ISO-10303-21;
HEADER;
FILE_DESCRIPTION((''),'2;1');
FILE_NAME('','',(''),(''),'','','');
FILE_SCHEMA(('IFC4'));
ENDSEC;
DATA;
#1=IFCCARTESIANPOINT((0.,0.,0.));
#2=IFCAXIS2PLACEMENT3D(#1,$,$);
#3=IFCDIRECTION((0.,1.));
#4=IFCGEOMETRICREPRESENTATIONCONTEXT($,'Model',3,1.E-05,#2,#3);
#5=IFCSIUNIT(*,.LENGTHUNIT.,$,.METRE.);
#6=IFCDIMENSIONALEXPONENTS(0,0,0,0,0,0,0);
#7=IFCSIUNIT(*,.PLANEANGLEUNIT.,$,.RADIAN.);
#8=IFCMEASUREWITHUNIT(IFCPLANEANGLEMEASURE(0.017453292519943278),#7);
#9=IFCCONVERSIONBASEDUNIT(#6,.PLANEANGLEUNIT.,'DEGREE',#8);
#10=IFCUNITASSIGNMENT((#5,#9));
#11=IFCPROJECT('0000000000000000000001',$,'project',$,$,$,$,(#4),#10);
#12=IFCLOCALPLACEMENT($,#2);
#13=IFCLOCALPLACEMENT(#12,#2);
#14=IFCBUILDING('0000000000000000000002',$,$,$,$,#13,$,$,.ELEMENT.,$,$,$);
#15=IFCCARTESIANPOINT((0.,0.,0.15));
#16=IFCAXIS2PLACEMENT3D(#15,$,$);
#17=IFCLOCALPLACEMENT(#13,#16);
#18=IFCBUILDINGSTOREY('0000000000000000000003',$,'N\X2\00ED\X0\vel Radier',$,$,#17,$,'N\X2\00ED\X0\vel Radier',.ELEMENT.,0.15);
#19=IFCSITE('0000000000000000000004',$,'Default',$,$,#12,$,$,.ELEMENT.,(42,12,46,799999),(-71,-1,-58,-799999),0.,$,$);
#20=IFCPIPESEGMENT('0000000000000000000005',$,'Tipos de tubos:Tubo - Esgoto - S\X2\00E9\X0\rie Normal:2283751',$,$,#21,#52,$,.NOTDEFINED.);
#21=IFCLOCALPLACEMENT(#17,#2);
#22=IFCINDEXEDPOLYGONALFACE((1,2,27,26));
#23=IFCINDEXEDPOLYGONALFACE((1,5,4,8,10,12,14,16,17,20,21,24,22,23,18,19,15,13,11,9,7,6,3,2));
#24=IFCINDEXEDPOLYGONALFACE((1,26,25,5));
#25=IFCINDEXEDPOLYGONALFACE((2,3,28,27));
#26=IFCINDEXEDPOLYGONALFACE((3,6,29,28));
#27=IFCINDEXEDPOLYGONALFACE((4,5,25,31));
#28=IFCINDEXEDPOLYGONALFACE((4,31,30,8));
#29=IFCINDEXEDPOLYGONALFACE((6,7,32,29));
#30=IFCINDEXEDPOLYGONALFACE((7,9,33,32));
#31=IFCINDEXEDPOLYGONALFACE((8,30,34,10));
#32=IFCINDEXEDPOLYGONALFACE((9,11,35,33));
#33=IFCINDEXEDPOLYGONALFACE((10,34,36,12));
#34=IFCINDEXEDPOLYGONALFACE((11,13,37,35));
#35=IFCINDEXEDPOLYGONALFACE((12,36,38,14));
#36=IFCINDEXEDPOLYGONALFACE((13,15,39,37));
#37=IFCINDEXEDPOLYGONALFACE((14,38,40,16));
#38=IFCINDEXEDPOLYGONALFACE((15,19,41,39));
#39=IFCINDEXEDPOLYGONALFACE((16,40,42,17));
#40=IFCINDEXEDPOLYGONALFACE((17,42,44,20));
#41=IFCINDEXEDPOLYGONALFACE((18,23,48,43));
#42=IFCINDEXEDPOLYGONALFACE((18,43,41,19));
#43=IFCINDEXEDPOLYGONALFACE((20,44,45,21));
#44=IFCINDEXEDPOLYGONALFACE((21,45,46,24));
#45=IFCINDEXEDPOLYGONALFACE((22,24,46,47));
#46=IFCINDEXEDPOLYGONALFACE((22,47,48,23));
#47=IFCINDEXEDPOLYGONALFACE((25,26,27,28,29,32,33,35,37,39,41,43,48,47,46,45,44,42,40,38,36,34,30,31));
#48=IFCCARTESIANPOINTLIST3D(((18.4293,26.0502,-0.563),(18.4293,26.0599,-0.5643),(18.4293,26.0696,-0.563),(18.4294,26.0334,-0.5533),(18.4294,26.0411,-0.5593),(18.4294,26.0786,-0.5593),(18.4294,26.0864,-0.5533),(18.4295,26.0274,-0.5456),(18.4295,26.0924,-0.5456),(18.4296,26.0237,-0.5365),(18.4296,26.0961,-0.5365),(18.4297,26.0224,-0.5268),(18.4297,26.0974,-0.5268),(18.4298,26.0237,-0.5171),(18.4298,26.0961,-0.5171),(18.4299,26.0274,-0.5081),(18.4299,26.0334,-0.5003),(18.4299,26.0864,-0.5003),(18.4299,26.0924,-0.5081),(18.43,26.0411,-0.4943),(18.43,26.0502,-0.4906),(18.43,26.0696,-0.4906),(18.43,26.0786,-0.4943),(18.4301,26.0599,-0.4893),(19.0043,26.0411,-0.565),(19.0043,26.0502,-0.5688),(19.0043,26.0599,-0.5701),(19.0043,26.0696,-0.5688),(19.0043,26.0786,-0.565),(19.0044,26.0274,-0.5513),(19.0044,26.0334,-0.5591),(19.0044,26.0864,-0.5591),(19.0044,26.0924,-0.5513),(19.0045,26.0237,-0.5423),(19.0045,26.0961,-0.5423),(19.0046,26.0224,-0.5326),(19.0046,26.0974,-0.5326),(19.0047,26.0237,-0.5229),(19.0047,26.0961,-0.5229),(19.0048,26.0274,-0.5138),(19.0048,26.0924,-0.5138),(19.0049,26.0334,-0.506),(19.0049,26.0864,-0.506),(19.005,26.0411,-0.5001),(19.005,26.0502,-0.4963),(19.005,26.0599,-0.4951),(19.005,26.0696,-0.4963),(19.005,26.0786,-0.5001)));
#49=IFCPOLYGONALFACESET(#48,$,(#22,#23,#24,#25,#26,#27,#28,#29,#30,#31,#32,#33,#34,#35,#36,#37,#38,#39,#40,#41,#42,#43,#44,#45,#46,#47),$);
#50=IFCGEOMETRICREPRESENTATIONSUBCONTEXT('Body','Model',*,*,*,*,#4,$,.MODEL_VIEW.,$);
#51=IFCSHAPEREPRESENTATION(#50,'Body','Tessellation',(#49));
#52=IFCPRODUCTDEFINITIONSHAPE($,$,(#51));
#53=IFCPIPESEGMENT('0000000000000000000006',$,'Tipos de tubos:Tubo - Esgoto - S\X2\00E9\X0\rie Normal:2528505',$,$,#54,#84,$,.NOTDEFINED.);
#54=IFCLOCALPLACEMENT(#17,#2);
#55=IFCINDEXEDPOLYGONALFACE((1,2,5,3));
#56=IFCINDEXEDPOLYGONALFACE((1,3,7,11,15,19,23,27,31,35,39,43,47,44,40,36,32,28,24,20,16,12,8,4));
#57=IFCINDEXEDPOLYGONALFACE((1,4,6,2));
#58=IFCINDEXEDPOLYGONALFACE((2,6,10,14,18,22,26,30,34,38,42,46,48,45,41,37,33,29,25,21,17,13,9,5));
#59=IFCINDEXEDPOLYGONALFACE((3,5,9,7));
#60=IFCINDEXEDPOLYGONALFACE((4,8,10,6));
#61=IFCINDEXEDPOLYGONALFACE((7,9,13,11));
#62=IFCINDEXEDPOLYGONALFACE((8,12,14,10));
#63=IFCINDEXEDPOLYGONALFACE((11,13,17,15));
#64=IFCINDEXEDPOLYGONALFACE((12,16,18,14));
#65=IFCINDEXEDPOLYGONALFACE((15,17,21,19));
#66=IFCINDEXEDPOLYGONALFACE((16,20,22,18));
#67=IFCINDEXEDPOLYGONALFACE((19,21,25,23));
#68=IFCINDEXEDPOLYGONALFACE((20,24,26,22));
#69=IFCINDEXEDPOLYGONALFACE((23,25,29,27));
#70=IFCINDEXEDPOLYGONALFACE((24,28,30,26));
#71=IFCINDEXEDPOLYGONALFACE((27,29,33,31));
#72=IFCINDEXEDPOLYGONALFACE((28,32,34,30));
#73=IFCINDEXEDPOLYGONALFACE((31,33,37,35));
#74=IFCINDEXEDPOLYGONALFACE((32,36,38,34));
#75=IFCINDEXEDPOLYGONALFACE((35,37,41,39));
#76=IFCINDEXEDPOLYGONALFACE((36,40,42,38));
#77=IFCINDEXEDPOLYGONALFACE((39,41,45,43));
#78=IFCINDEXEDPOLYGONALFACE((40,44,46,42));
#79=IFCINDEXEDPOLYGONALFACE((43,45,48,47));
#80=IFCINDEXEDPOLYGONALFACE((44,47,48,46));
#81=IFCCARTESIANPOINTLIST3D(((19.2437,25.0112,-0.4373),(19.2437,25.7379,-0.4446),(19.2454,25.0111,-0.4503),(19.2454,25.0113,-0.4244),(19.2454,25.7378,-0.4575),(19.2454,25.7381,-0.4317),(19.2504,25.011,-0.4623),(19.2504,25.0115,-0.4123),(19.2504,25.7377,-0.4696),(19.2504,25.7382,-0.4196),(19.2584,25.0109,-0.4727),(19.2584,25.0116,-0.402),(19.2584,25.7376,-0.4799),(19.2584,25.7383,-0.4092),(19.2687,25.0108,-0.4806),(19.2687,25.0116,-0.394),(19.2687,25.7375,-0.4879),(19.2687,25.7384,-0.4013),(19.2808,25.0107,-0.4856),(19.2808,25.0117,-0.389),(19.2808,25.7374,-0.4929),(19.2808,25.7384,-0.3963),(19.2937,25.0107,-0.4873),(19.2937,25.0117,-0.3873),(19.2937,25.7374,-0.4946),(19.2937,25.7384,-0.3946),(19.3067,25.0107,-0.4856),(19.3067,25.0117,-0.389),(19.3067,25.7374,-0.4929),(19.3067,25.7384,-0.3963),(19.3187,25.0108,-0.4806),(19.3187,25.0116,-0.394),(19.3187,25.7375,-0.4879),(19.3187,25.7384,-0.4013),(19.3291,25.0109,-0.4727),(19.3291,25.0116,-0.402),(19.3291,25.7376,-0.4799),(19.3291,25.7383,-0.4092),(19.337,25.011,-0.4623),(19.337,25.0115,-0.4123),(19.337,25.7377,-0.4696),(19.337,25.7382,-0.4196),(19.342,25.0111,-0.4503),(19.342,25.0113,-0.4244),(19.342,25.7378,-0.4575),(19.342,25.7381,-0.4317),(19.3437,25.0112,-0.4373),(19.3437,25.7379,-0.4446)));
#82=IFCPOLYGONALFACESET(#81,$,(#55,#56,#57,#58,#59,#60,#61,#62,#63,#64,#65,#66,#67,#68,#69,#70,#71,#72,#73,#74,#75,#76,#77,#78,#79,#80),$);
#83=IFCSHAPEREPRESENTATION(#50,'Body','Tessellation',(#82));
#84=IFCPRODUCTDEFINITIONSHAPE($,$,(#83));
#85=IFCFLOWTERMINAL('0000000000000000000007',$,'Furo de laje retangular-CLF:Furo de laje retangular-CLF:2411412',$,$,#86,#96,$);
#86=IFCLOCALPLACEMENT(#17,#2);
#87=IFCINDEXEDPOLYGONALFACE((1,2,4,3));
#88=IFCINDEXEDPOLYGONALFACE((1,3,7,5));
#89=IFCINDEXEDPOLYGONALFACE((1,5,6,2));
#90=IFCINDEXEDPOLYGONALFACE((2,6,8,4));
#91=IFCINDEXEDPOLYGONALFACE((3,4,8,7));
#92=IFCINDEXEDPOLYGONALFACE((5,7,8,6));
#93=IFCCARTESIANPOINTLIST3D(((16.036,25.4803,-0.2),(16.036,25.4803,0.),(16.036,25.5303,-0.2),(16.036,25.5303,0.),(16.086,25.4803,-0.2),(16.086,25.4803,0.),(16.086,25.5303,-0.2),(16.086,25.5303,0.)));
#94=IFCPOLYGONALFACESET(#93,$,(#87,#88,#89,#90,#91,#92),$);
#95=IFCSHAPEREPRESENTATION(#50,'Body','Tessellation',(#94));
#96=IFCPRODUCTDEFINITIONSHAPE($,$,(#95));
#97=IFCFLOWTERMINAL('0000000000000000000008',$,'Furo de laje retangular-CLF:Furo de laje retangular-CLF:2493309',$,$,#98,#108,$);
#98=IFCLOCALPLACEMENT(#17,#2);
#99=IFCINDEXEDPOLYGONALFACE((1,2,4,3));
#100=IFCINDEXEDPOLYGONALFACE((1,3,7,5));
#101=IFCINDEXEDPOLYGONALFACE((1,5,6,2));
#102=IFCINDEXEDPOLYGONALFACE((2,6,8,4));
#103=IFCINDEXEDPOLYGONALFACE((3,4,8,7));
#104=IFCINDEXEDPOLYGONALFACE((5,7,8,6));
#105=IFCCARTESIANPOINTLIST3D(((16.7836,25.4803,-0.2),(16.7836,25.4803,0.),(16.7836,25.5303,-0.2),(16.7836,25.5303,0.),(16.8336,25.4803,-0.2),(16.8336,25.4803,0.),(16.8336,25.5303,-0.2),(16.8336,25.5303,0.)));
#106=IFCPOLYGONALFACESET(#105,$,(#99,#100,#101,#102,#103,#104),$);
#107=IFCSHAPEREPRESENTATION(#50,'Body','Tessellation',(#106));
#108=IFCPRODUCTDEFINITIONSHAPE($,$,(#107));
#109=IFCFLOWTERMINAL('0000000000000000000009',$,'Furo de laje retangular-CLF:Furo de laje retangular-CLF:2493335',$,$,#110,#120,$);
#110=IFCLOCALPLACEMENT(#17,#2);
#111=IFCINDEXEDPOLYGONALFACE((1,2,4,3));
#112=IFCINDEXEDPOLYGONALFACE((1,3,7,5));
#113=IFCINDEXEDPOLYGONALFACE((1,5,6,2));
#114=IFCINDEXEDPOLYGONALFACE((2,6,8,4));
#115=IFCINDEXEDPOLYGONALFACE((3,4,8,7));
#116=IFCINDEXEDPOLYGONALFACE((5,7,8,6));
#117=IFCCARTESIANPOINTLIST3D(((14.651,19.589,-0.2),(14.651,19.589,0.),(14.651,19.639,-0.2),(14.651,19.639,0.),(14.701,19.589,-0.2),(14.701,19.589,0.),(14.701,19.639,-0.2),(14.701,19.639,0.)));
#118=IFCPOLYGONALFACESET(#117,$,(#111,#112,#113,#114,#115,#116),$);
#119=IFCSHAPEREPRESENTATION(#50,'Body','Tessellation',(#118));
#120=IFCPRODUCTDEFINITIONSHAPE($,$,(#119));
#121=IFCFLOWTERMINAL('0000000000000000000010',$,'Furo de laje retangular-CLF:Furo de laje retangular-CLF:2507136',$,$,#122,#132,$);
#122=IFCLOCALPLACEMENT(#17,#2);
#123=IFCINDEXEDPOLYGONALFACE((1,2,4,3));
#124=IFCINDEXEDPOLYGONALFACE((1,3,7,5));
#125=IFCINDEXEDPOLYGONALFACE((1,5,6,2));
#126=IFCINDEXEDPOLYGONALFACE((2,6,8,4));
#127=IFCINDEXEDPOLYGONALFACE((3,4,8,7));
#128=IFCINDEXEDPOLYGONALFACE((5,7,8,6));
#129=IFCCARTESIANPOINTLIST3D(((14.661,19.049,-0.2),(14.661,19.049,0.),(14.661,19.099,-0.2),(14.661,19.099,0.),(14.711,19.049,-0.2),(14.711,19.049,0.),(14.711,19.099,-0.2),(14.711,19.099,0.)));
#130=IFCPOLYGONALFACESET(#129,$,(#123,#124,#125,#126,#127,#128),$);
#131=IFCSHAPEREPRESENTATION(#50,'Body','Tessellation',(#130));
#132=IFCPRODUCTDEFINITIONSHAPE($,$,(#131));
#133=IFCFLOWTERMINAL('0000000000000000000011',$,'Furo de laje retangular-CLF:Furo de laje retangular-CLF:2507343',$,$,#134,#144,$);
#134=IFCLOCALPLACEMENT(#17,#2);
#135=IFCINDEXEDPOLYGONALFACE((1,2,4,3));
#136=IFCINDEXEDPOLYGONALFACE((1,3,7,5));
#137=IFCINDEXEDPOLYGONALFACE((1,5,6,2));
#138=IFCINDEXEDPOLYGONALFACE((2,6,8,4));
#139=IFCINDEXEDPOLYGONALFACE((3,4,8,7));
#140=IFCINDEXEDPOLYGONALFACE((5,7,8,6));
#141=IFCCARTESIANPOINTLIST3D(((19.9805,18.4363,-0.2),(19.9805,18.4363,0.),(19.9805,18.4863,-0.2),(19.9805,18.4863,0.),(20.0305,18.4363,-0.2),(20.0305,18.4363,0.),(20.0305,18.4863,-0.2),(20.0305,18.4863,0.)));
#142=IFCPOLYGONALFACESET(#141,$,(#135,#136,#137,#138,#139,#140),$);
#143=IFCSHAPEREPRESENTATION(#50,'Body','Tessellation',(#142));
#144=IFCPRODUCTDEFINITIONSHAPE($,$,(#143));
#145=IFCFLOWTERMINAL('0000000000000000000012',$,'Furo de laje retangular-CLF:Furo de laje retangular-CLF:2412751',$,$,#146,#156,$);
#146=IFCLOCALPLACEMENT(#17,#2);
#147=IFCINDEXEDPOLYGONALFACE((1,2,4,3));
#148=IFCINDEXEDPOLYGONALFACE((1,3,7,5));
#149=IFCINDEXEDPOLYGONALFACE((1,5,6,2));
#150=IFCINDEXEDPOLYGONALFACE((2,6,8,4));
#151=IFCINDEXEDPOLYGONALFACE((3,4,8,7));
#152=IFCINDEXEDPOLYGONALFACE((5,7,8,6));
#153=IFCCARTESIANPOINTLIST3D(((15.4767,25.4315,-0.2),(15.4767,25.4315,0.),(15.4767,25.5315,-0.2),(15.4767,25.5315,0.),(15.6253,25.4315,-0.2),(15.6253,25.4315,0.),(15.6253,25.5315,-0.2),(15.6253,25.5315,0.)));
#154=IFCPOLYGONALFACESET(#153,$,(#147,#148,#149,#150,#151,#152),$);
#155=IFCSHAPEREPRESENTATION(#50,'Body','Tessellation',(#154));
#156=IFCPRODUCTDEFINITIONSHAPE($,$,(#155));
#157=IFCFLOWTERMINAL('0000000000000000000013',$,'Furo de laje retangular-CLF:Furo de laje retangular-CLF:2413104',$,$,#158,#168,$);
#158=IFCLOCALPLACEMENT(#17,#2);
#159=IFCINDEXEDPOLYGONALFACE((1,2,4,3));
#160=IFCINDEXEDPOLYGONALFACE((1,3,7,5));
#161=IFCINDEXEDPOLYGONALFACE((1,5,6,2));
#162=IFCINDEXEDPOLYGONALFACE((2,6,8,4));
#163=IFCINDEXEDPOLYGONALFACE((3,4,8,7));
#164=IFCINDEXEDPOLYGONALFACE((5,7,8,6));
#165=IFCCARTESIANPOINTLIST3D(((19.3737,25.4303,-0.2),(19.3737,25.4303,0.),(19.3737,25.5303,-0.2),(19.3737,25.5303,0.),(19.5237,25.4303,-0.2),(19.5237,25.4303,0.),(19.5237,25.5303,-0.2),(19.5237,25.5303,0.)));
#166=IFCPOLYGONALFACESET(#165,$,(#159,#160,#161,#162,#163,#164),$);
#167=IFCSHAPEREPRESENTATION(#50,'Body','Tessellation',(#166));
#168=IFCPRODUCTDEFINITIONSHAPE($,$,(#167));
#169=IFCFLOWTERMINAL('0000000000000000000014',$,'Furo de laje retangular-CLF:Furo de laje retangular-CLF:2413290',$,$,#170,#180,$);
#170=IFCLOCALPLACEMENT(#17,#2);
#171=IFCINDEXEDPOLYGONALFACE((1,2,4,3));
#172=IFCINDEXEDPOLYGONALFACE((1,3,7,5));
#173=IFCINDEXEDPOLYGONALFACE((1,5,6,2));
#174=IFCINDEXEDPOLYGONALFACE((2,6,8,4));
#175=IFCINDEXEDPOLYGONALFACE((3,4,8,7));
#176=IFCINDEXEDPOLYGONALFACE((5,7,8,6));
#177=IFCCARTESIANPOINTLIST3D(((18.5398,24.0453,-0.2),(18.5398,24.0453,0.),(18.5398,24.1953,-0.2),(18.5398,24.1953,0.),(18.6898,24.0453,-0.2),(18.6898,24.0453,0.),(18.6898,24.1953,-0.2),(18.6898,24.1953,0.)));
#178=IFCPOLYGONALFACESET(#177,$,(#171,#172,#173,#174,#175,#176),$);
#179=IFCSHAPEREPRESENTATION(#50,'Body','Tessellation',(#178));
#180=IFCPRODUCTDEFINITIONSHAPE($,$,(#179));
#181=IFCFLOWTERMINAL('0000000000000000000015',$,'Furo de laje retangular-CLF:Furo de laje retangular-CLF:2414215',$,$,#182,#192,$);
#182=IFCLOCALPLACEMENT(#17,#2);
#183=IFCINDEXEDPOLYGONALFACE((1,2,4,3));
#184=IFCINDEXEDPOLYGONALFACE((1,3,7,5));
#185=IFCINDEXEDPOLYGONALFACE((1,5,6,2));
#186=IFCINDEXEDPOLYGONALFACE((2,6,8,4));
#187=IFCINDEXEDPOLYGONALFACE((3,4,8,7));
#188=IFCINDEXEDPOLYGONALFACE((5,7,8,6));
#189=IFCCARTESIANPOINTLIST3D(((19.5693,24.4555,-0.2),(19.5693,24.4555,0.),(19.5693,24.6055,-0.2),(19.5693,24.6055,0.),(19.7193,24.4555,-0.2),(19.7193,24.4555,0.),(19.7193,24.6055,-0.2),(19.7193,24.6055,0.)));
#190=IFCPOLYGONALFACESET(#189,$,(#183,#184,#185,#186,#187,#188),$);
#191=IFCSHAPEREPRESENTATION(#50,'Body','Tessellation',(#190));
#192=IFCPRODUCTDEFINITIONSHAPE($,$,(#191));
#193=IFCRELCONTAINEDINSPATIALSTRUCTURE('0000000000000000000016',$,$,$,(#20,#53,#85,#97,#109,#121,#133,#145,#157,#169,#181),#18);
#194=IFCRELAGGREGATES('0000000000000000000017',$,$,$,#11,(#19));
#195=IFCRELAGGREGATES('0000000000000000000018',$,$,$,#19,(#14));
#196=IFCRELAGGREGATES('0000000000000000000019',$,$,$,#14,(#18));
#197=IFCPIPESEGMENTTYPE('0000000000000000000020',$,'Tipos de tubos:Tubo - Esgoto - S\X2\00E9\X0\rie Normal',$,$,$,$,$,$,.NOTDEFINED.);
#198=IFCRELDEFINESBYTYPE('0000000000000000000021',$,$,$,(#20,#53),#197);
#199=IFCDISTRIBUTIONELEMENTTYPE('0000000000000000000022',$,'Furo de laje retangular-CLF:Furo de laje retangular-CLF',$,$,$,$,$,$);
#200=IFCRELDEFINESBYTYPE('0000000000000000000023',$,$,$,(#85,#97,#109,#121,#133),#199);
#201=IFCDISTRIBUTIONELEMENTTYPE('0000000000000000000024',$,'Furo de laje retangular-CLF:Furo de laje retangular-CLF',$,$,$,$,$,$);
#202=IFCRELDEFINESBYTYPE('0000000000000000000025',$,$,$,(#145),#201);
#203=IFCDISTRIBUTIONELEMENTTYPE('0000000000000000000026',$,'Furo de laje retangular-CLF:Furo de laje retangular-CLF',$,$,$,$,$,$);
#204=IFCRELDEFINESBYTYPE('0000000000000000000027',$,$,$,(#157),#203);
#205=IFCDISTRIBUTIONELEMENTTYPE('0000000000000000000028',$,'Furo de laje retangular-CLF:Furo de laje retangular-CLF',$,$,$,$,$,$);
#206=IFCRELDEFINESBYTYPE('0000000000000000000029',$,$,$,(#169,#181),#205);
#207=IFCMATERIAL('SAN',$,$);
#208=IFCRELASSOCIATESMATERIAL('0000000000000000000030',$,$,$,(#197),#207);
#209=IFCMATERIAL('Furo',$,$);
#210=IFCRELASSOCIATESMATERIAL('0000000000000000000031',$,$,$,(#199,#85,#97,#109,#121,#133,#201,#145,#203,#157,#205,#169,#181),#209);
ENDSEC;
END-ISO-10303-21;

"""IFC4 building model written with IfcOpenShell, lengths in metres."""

from ifc_helpers import new_model, entity, si_unit, converted_unit, direction, frame, origin, place, context, subcontext, project, spatial, arc, indexed_curve, outline, extrude, source, transform, mapped, material, type_object, type_shapes, element, save


model = new_model("IFC4")

# Units and contexts
model_context = context("Model", 3, precision=1e-05, world=origin(), true_north=direction((0.0, 1.0)))
body_context = subcontext(model_context, "Body", "Model", "MODEL_VIEW")
ifc_project = project(units=[si_unit("LENGTHUNIT", "METRE"), converted_unit("PLANEANGLEUNIT", "DEGREE", entity("IfcPlaneAngleMeasure", 0.017453292519943278), si_unit("PLANEANGLEUNIT", "RADIAN"), dimensions=[0, 0, 0, 0, 0, 0, 0])], contexts=[model_context])

# Site, building, storey
site_placement = place(None, origin())
site = spatial("IfcSite", under=ifc_project, at=site_placement, Name="Default", CompositionType="ELEMENT", RefLatitude=(42, 12, 46, 799999), RefLongitude=(-71, -1, -58, -799999), RefElevation=0.0)
building_placement = place(site_placement, origin())
building = spatial("IfcBuilding", under=site, at=building_placement, CompositionType="ELEMENT")
storey_placement = place(building_placement, frame((0.0, 0.0, 0.15)))
storey = spatial("IfcBuildingStorey", under=building, at=storey_placement, Name="Nível Radier", LongName="Nível Radier", CompositionType="ELEMENT", Elevation=0.15)

# Pipe segments
ifc_material_1 = material(Name="SAN")
pipe_segment_type = type_object("IfcPipeSegmentType", Name="Tipos de tubos:Tubo - Esgoto - Série Normal", PredefinedType="NOTDEFINED", material=ifc_material_1)
pipe_segment_1_placement = place(storey_placement, origin())
element("IfcPipeSegment", 1, at=pipe_segment_1_placement, inside=storey, type_object=pipe_segment_type, Name="Tipos de tubos:Tubo - Esgoto - Série Normal:2283751", PredefinedType="NOTDEFINED", context=body_context, shape_type="SweptSolid", body=[
    extrude(outline(indexed_curve([(0.0375, 0.0), (0.0265, 0.0265), (0.0, 0.0375), (-0.0265, 0.0265), (-0.0375, 0.0), (-0.0265, -0.0265), (0.0, -0.0375), (0.0265, -0.0265)], segments=[arc(1, 2, 3), arc(3, 4, 5), arc(5, 6, 7), arc(7, 8, 1)], self_intersect=False)), frame((19.0046, 26.0599, -0.5326), z_axis=(-0.99995, -0.000003, 0.01), x_axis=(0.000003, -1.0, 0.0)), (0.0, 0.0, 1.0), 0.575),
])
pipe_segment_2_placement = place(storey_placement, origin())
element("IfcPipeSegment", 2, at=pipe_segment_2_placement, inside=storey, type_object=pipe_segment_type, Name="Tipos de tubos:Tubo - Esgoto - Série Normal:2528505", PredefinedType="NOTDEFINED", context=body_context, shape_type="SweptSolid", body=[
    extrude(outline(indexed_curve([(0.05, 0.0), (0.0354, 0.0354), (0.0, 0.05), (-0.0354, 0.0354), (-0.05, 0.0), (-0.0354, -0.0354), (0.0, -0.05), (0.0354, -0.0354)], segments=[arc(1, 2, 3), arc(3, 4, 5), arc(5, 6, 7), arc(7, 8, 1)], self_intersect=False)), frame((19.2937, 25.0112, -0.4373), z_axis=(0.0, 0.99995, -0.01), x_axis=(1.0, 0.0, 0.0)), (0.0, 0.0, 1.0), 0.7268),
])

# Flow terminals
ifc_material_2 = material(Name="Furo")
distribution_element_type_1 = type_object("IfcDistributionElementType", Name="Furo de laje retangular-CLF:Furo de laje retangular-CLF", material=ifc_material_2)
shared_shape_1 = source(origin(), body_context, "Body", "SweptSolid", [
    extrude(outline(indexed_curve([(-0.025, -0.025), (0.025, -0.025), (0.025, 0.025), (-0.025, 0.025), (-0.025, -0.025)], self_intersect=False)), frame((0.0, 0.0, -0.2), z_axis=(0.0, 0.0, 1.0), x_axis=(0.0, 1.0, 0.0)), (0.0, 0.0, 1.0), 0.2),
])
type_shapes(distribution_element_type_1, [shared_shape_1])
for number, where, z_axis, x_axis, name in (
    (3, (16.061, 25.5053, 0.0), (0.0, 0.0, 1.0), (-1.0, 0.0, 0.0), "Furo de laje retangular-CLF:Furo de laje retangular-CLF:2411412"),
    (4, (16.8086, 25.5053, 0.0), (0.0, 0.0, 1.0), (-1.0, 0.0, 0.0), "Furo de laje retangular-CLF:Furo de laje retangular-CLF:2493309"),
    (5, (14.676, 19.614, 0.0), (0.0, 0.0, 1.0), (-1.0, 0.0, 0.0), "Furo de laje retangular-CLF:Furo de laje retangular-CLF:2493335"),
    (6, (14.686, 19.074, 0.0), (0.0, 0.0, 1.0), (-1.0, 0.0, 0.0), "Furo de laje retangular-CLF:Furo de laje retangular-CLF:2507136"),
    (7, (20.0055, 18.4613, 0.0), (0.0, 0.0, 1.0), (-1.0, 0.0, 0.0), "Furo de laje retangular-CLF:Furo de laje retangular-CLF:2507343"),
):
    element("IfcFlowTerminal", number, at=place(storey_placement, frame(where, z_axis=z_axis, x_axis=x_axis)), inside=storey, type_object=distribution_element_type_1, material=ifc_material_2, Name=name, context=body_context, shape_type="MappedRepresentation", body=[
        mapped(shared_shape_1, transform((0.0, 0.0, 0.0), scale=1.0)),
    ])
distribution_element_type_2 = type_object("IfcDistributionElementType", Name="Furo de laje retangular-CLF:Furo de laje retangular-CLF", material=ifc_material_2)
shared_shape_2 = source(origin(), body_context, "Body", "SweptSolid", [
    extrude(outline(indexed_curve([(-0.05, -0.0743), (0.05, -0.0743), (0.05, 0.0743), (-0.05, 0.0743), (-0.05, -0.0743)], self_intersect=False)), frame((0.0, 0.0, -0.2), z_axis=(0.0, 0.0, 1.0), x_axis=(0.0, 1.0, 0.0)), (0.0, 0.0, 1.0), 0.2),
])
type_shapes(distribution_element_type_2, [shared_shape_2])
flow_terminal_1_placement = place(storey_placement, frame((15.551, 25.4815, 0.0), z_axis=(0.0, 0.0, 1.0), x_axis=(-1.0, 0.0, 0.0)))
element("IfcFlowTerminal", 8, at=flow_terminal_1_placement, inside=storey, type_object=distribution_element_type_2, material=ifc_material_2, Name="Furo de laje retangular-CLF:Furo de laje retangular-CLF:2412751", context=body_context, shape_type="MappedRepresentation", body=[
    mapped(shared_shape_2, transform((0.0, 0.0, 0.0), scale=1.0)),
])
distribution_element_type_3 = type_object("IfcDistributionElementType", Name="Furo de laje retangular-CLF:Furo de laje retangular-CLF", material=ifc_material_2)
shared_shape_3 = source(origin(), body_context, "Body", "SweptSolid", [
    extrude(outline(indexed_curve([(-0.05, -0.075), (0.05, -0.075), (0.05, 0.075), (-0.05, 0.075), (-0.05, -0.075)], self_intersect=False)), frame((0.0, 0.0, -0.2), z_axis=(0.0, 0.0, 1.0), x_axis=(0.0, 1.0, 0.0)), (0.0, 0.0, 1.0), 0.2),
])
type_shapes(distribution_element_type_3, [shared_shape_3])
flow_terminal_2_placement = place(storey_placement, frame((19.4487, 25.4803, 0.0), z_axis=(0.0, 0.0, 1.0), x_axis=(-1.0, 0.0, 0.0)))
element("IfcFlowTerminal", 9, at=flow_terminal_2_placement, inside=storey, type_object=distribution_element_type_3, material=ifc_material_2, Name="Furo de laje retangular-CLF:Furo de laje retangular-CLF:2413104", context=body_context, shape_type="MappedRepresentation", body=[
    mapped(shared_shape_3, transform((0.0, 0.0, 0.0), scale=1.0)),
])
distribution_element_type_4 = type_object("IfcDistributionElementType", Name="Furo de laje retangular-CLF:Furo de laje retangular-CLF", material=ifc_material_2)
shared_shape_4 = source(origin(), body_context, "Body", "SweptSolid", [
    extrude(outline(indexed_curve([(-0.075, -0.075), (0.075, -0.075), (0.075, 0.075), (-0.075, 0.075), (-0.075, -0.075)], self_intersect=False)), frame((0.0, 0.0, -0.2), z_axis=(0.0, 0.0, 1.0), x_axis=(0.0, 1.0, 0.0)), (0.0, 0.0, 1.0), 0.2),
])
type_shapes(distribution_element_type_4, [shared_shape_4])
for number, where, z_axis, x_axis, name in (
    (10, (18.6148, 24.1203, 0.0), (0.0, 0.0, 1.0), (-1.0, 0.0, 0.0), "Furo de laje retangular-CLF:Furo de laje retangular-CLF:2413290"),
    (11, (19.6443, 24.5305, 0.0), (0.0, 0.0, 1.0), (-1.0, 0.0, 0.0), "Furo de laje retangular-CLF:Furo de laje retangular-CLF:2414215"),
):
    element("IfcFlowTerminal", number, at=place(storey_placement, frame(where, z_axis=z_axis, x_axis=x_axis)), inside=storey, type_object=distribution_element_type_4, material=ifc_material_2, Name=name, context=body_context, shape_type="MappedRepresentation", body=[
        mapped(shared_shape_4, transform((0.0, 0.0, 0.0), scale=1.0)),
    ])

save(model, "model.ifc")
